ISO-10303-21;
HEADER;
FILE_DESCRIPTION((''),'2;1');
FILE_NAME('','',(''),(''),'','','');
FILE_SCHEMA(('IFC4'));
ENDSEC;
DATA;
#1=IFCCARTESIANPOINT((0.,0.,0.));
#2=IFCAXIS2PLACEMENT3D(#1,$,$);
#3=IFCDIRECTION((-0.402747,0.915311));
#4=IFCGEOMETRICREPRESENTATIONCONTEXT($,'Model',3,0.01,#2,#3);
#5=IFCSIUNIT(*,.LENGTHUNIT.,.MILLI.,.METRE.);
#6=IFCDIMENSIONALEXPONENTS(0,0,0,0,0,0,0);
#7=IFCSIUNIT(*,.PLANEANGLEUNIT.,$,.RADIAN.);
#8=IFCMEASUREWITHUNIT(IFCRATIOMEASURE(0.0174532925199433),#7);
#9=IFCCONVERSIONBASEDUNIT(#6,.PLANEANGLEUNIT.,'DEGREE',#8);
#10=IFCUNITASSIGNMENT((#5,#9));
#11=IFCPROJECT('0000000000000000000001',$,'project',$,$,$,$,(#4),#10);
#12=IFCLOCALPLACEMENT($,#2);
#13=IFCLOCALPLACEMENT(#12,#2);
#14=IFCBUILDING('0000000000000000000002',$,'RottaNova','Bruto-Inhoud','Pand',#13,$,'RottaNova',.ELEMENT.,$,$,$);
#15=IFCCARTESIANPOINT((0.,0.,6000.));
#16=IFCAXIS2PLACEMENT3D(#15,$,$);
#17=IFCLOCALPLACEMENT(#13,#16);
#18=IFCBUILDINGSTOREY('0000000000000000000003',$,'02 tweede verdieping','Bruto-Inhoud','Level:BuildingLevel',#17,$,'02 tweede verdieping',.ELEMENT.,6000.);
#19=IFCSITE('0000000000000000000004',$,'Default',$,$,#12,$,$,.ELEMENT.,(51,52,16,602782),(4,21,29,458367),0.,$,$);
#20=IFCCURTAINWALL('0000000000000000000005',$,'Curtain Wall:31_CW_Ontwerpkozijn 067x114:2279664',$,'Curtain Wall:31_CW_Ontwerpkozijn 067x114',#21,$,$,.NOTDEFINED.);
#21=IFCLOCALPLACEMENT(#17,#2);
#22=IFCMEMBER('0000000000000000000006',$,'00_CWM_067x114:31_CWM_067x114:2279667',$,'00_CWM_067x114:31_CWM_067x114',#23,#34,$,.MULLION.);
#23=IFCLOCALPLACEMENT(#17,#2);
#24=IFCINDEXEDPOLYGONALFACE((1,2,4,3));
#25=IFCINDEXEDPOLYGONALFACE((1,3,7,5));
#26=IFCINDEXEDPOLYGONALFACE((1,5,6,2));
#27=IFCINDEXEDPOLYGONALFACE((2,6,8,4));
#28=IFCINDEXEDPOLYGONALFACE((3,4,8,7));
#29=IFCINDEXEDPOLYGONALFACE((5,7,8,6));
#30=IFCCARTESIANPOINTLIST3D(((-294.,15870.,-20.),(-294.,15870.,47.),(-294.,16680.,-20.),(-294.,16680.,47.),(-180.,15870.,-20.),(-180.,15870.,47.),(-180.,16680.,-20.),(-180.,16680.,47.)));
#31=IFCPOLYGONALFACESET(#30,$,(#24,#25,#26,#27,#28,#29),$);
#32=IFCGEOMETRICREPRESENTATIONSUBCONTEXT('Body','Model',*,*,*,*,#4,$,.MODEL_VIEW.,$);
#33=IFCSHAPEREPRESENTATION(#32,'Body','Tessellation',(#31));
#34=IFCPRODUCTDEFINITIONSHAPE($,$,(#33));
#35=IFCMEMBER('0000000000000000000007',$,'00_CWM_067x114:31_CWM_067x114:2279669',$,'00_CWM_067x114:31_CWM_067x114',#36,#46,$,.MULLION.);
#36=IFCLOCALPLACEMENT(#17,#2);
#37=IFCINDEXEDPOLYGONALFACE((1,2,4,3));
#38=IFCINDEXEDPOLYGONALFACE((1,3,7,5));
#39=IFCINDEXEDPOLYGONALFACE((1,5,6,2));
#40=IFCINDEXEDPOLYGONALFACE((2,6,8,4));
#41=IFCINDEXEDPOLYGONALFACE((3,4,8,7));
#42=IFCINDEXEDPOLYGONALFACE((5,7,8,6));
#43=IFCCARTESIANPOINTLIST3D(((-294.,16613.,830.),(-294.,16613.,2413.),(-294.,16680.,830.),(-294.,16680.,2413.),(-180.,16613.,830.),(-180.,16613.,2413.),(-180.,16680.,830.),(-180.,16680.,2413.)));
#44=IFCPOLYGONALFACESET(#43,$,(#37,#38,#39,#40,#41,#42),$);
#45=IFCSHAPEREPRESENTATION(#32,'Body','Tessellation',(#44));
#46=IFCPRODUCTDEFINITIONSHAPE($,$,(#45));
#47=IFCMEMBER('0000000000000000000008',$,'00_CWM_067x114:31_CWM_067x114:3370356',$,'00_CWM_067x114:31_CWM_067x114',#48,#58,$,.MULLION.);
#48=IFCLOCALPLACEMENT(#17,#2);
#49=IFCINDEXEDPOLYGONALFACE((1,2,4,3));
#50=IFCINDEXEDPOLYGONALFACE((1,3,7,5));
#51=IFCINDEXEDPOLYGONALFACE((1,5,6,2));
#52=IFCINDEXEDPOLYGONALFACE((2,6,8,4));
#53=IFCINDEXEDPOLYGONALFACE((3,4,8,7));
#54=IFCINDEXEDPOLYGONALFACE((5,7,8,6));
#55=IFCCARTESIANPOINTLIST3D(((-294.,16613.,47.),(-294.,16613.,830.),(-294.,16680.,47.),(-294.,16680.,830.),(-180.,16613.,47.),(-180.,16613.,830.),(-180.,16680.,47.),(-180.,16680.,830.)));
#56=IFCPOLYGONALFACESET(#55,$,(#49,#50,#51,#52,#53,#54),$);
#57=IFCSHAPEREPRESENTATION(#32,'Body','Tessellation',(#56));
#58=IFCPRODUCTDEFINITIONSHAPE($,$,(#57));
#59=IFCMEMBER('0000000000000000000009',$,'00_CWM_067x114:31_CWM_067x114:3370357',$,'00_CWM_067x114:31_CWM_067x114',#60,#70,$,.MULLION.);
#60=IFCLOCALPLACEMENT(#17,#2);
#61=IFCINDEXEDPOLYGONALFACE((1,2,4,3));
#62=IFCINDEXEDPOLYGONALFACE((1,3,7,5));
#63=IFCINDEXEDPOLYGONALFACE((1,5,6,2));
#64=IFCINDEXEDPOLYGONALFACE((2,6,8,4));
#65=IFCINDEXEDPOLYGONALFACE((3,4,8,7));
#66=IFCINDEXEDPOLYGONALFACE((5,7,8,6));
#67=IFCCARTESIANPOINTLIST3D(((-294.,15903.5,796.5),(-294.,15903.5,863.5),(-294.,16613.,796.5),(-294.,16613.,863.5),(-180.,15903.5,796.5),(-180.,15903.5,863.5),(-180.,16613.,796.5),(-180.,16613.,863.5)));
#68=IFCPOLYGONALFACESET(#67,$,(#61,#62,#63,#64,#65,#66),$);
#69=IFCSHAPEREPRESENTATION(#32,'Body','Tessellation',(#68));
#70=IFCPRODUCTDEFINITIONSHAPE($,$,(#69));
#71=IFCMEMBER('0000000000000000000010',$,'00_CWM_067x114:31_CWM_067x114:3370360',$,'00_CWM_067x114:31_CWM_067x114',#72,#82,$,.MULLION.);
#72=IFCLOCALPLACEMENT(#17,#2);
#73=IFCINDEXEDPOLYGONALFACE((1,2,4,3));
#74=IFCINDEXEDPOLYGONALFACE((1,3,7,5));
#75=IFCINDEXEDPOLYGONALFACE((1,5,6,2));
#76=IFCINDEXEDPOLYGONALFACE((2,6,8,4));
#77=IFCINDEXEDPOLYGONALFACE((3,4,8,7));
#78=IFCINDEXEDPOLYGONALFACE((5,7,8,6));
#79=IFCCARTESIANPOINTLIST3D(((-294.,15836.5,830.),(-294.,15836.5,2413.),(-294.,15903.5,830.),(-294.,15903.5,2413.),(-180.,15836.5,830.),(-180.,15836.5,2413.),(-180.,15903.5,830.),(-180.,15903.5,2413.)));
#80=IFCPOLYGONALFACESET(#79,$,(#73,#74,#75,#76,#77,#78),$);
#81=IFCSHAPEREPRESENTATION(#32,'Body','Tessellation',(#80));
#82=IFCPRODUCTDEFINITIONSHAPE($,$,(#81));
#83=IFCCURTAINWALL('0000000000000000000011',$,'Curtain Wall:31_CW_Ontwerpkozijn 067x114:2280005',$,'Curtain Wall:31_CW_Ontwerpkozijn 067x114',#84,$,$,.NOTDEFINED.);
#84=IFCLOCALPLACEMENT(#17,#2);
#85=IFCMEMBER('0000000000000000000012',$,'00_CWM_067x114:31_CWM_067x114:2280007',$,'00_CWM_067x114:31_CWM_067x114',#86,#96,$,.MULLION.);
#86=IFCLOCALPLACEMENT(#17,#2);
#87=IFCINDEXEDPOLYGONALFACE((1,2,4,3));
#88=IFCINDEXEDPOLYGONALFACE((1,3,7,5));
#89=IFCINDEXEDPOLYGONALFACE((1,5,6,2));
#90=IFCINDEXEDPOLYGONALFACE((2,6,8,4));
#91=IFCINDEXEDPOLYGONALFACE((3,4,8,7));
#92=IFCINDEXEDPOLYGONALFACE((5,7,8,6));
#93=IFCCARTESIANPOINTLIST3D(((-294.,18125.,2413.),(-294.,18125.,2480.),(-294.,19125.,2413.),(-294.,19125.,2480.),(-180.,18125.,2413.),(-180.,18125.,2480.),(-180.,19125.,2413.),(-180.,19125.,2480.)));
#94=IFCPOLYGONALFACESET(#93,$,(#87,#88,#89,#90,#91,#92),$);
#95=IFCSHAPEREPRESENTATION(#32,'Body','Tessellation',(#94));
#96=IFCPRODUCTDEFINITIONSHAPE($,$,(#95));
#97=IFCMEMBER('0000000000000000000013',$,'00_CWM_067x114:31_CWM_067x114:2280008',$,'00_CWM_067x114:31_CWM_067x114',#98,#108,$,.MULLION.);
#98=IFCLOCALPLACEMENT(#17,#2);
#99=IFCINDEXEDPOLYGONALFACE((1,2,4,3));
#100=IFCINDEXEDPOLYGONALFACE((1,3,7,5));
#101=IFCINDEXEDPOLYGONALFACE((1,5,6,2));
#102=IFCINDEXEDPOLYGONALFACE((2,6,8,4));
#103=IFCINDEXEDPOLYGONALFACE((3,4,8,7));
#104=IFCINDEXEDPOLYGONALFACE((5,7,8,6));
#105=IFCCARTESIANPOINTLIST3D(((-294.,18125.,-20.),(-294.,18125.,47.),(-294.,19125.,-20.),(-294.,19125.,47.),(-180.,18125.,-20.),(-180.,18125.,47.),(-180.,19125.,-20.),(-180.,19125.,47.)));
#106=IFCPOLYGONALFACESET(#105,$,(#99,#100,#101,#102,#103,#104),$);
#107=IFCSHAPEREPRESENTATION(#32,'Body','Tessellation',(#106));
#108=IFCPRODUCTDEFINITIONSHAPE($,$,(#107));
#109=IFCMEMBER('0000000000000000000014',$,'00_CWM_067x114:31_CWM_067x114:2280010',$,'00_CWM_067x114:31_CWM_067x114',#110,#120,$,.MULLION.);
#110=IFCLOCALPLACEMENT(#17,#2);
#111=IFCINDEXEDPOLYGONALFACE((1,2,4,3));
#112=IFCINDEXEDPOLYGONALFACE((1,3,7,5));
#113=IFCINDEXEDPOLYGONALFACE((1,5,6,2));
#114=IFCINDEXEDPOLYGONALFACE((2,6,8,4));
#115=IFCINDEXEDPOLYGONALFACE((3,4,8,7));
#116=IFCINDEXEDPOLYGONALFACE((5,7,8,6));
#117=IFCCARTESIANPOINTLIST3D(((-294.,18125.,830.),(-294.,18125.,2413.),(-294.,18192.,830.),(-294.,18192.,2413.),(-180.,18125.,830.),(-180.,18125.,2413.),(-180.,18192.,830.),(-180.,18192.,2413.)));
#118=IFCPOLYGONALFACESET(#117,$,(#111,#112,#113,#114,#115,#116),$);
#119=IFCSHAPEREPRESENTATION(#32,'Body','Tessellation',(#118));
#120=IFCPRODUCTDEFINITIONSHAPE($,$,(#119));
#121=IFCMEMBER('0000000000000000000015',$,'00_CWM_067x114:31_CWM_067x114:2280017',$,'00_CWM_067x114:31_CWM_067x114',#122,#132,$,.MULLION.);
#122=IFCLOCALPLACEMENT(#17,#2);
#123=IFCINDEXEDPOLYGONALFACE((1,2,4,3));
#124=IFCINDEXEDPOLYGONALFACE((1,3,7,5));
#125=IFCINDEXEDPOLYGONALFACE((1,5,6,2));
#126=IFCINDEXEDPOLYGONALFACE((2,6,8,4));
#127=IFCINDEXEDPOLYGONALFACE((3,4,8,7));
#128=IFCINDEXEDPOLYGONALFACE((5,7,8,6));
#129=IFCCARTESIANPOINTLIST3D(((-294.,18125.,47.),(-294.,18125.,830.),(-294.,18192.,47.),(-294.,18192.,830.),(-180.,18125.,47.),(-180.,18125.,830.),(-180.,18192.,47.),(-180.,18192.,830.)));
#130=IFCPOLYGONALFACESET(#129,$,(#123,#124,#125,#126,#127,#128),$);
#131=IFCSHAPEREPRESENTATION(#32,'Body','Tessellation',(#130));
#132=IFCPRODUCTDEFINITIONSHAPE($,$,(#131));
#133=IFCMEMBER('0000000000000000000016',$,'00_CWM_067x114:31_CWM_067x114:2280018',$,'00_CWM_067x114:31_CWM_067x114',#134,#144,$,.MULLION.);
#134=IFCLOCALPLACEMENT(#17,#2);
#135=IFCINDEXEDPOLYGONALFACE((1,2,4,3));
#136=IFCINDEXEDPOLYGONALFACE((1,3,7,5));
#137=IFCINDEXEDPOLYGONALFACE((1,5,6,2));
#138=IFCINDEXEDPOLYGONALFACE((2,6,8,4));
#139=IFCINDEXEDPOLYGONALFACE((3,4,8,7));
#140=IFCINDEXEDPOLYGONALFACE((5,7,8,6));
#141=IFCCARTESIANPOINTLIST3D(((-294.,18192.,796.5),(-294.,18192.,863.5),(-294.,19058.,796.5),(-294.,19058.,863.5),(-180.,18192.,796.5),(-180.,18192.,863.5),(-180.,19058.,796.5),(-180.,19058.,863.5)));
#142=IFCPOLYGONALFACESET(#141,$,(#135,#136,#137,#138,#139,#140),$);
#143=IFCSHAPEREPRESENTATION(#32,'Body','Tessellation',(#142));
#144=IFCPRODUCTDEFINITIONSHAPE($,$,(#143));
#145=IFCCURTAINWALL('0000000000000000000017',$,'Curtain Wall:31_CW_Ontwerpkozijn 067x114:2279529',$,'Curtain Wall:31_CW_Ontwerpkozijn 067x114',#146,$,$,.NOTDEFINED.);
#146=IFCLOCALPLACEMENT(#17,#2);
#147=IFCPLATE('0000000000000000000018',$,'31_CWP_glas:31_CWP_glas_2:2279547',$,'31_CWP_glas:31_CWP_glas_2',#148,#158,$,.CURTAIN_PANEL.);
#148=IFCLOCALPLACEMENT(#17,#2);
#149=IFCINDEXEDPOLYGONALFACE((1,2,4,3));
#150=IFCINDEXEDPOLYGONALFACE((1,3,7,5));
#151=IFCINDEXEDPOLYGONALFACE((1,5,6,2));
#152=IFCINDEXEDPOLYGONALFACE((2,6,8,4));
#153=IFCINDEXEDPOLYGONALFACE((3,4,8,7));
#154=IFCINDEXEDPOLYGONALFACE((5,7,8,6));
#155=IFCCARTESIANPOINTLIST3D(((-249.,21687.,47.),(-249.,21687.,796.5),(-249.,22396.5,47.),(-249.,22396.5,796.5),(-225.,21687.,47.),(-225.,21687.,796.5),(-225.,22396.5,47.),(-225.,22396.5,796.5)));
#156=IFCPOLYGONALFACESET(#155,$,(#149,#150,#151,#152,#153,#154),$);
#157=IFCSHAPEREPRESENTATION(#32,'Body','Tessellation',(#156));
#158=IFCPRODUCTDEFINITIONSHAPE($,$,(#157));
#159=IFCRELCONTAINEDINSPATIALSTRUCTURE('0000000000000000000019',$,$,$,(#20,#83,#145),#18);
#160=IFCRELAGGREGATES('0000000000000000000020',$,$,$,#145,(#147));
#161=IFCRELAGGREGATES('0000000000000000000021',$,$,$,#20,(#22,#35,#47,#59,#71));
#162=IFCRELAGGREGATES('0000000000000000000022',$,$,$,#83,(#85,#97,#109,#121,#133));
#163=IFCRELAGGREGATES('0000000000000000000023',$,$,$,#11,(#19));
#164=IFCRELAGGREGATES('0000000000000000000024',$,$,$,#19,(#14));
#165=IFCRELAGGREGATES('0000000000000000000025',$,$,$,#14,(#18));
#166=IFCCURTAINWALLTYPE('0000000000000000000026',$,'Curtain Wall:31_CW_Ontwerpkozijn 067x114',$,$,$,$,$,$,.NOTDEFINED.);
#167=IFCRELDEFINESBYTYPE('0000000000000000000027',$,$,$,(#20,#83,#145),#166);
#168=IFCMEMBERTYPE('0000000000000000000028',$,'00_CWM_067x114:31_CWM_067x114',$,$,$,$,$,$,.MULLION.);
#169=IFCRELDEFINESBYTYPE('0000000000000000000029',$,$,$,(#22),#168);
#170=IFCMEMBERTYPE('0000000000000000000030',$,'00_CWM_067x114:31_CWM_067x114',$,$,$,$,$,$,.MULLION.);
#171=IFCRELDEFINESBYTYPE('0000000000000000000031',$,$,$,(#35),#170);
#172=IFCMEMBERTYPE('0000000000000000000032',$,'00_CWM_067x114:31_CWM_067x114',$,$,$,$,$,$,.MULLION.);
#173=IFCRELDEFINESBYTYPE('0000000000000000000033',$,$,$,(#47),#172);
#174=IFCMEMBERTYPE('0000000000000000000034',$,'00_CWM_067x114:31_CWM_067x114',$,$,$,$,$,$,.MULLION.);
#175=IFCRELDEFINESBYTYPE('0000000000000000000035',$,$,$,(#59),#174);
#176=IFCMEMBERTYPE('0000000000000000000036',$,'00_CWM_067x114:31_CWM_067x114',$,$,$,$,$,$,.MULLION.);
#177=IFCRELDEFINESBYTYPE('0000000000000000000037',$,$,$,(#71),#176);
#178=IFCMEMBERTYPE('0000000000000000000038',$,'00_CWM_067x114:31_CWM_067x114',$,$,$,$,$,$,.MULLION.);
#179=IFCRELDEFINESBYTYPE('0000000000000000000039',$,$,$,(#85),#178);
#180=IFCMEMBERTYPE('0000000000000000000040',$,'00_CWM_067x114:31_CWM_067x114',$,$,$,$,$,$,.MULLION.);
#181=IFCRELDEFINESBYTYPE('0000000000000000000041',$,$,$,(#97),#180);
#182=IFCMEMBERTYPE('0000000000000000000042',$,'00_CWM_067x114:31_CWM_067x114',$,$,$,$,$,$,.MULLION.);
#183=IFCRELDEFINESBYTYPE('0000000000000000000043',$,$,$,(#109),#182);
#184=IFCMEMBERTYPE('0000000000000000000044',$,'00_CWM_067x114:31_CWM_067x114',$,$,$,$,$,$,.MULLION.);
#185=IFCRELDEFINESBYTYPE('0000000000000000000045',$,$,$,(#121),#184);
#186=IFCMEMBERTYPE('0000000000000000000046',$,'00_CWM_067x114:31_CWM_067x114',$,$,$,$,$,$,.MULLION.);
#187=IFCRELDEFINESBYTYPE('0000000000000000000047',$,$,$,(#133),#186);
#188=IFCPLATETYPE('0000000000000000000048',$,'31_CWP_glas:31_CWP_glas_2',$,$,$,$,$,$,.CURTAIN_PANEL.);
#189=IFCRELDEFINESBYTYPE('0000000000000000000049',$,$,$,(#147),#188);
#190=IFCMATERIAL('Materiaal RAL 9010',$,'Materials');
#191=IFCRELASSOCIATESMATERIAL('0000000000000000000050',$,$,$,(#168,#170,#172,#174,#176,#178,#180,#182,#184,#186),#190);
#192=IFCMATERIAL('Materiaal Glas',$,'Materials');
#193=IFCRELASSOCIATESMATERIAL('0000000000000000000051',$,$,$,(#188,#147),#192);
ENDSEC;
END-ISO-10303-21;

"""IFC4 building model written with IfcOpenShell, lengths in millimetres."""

from ifc_helpers import new_model, entity, si_unit, converted_unit, direction, frame, frame_2d, origin, origin_2d_with_axis, place, context, subcontext, project, spatial, rectangle, extrude, source, transform, mapped, material, material_profile, profile_set, type_object, type_shapes, element, aggregate, save


model = new_model("IFC4")

# Units and contexts
model_context = context("Model", 3, precision=0.01, world=origin(), true_north=direction((-0.402747, 0.915311)))
body_context = subcontext(model_context, "Body", "Model", "MODEL_VIEW")
ifc_project = project(units=[si_unit("LENGTHUNIT", "METRE", prefix="MILLI"), converted_unit("PLANEANGLEUNIT", "DEGREE", entity("IfcRatioMeasure", 0.0174532925199433), si_unit("PLANEANGLEUNIT", "RADIAN"), dimensions=[0, 0, 0, 0, 0, 0, 0])], contexts=[model_context])

# Site, building, storey
site_placement = place(None, origin())
site = spatial("IfcSite", under=ifc_project, at=site_placement, Name="Default", CompositionType="ELEMENT", RefLatitude=(51, 52, 16, 602782), RefLongitude=(4, 21, 29, 458367), RefElevation=0.0)
building_placement = place(site_placement, origin())
building = spatial("IfcBuilding", under=site, at=building_placement, Name="RottaNova", Description="Bruto-Inhoud", ObjectType="Pand", LongName="RottaNova", CompositionType="ELEMENT")
storey_placement = place(building_placement, frame((0.0, 0.0, 6000.0)))
storey = spatial("IfcBuildingStorey", under=building, at=storey_placement, Name="02 tweede verdieping", Description="Bruto-Inhoud", ObjectType="Level:BuildingLevel", LongName="02 tweede verdieping", CompositionType="ELEMENT", Elevation=6000.0)

# Curtain walls, members
curtain_wall_type = type_object("IfcCurtainWallType", Name="Curtain Wall:31_CW_Ontwerpkozijn 067x114", PredefinedType="NOTDEFINED")
curtain_wall_1_placement = place(storey_placement, frame((0.0, 0.0, -6000.0)))
curtain_wall_1 = element("IfcCurtainWall", 1, at=curtain_wall_1_placement, inside=storey, type_object=curtain_wall_type, Name="Curtain Wall:31_CW_Ontwerpkozijn 067x114:2279664", ObjectType="Curtain Wall:31_CW_Ontwerpkozijn 067x114", PredefinedType="NOTDEFINED")
ifc_material_1 = material(Name="Materiaal RAL 9010", Category="Materials")
ifc_material_profile = material_profile(ifc_material_1, rectangle(XDim=114.0, YDim=67.0, at=origin_2d_with_axis()), Name="31_CWM_067x114")
ifc_profile_set = profile_set([ifc_material_profile], Name="31_CWM_067x114")
member_type_1 = type_object("IfcMemberType", Name="00_CWM_067x114:31_CWM_067x114", PredefinedType="MULLION", material=ifc_profile_set)
shared_shape_1 = source(origin(), body_context, "Body", "SweptSolid", [
    extrude(rectangle(XDim=114.0, YDim=67.0, at=origin_2d_with_axis()), frame((-33.5, 57.0, -810.0), z_axis=(0.0, 0.0, 1.0), x_axis=(0.0, -1.0, 0.0)), (0.0, 0.0, 1.0), 810.0),
])
type_shapes(member_type_1, [shared_shape_1])
member_1_placement = place(curtain_wall_1_placement, frame((-180.0, 16680.0, 5980.0), z_axis=(0.0, 1.0, 0.0), x_axis=(0.0, 0.0, -1.0)))
member_1 = element("IfcMember", 2, at=member_1_placement, type_object=member_type_1, Name="00_CWM_067x114:31_CWM_067x114:2279667", ObjectType="00_CWM_067x114:31_CWM_067x114", PredefinedType="MULLION", context=body_context, shape_type="MappedRepresentation", body=[
    mapped(shared_shape_1, transform((0.0, 0.0, 0.0), scale=1.0)),
])
member_type_2 = type_object("IfcMemberType", Name="00_CWM_067x114:31_CWM_067x114", PredefinedType="MULLION", material=ifc_profile_set)
shared_shape_2 = source(origin(), body_context, "Body", "SweptSolid", [
    extrude(rectangle(XDim=114.0, YDim=67.0, at=origin_2d_with_axis()), frame((-33.5, 57.0, -1583.0), z_axis=(0.0, 0.0, 1.0), x_axis=(0.0, -1.0, 0.0)), (0.0, 0.0, 1.0), 1583.0),
])
type_shapes(member_type_2, [shared_shape_2])
member_2_placement = place(curtain_wall_1_placement, frame((-180.0, 16680.0, 8413.0), z_axis=(0.0, 0.0, 1.0), x_axis=(0.0, 1.0, 0.0)))
member_2 = element("IfcMember", 3, at=member_2_placement, type_object=member_type_2, Name="00_CWM_067x114:31_CWM_067x114:2279669", ObjectType="00_CWM_067x114:31_CWM_067x114", PredefinedType="MULLION", context=body_context, shape_type="MappedRepresentation", body=[
    mapped(shared_shape_2, transform((0.0, 0.0, 0.0), scale=1.0)),
])
member_type_3 = type_object("IfcMemberType", Name="00_CWM_067x114:31_CWM_067x114", PredefinedType="MULLION", material=ifc_profile_set)
shared_shape_3 = source(origin(), body_context, "Body", "SweptSolid", [
    extrude(rectangle(XDim=114.0, YDim=67.0, at=origin_2d_with_axis()), frame((-33.5, 57.0, -783.0), z_axis=(0.0, 0.0, 1.0), x_axis=(0.0, -1.0, 0.0)), (0.0, 0.0, 1.0), 783.0),
])
type_shapes(member_type_3, [shared_shape_3])
member_3_placement = place(curtain_wall_1_placement, frame((-180.0, 16680.0, 6830.0), z_axis=(0.0, 0.0, 1.0), x_axis=(0.0, 1.0, 0.0)))
member_3 = element("IfcMember", 4, at=member_3_placement, type_object=member_type_3, Name="00_CWM_067x114:31_CWM_067x114:3370356", ObjectType="00_CWM_067x114:31_CWM_067x114", PredefinedType="MULLION", context=body_context, shape_type="MappedRepresentation", body=[
    mapped(shared_shape_3, transform((0.0, 0.0, 0.0), scale=1.0)),
])
member_type_4 = type_object("IfcMemberType", Name="00_CWM_067x114:31_CWM_067x114", PredefinedType="MULLION", material=ifc_profile_set)
shared_shape_4 = source(origin(), body_context, "Body", "SweptSolid", [
    extrude(rectangle(XDim=114.0, YDim=67.0, at=origin_2d_with_axis()), frame((0.0, 57.0, -709.5), z_axis=(0.0, 0.0, 1.0), x_axis=(0.0, -1.0, 0.0)), (0.0, 0.0, 1.0), 709.5),
])
type_shapes(member_type_4, [shared_shape_4])
member_4_placement = place(curtain_wall_1_placement, frame((-180.0, 15903.5, 6830.0), z_axis=(0.0, -1.0, 0.0), x_axis=(0.0, 0.0, 1.0)))
member_4 = element("IfcMember", 5, at=member_4_placement, type_object=member_type_4, Name="00_CWM_067x114:31_CWM_067x114:3370357", ObjectType="00_CWM_067x114:31_CWM_067x114", PredefinedType="MULLION", context=body_context, shape_type="MappedRepresentation", body=[
    mapped(shared_shape_4, transform((0.0, 0.0, 0.0), scale=1.0)),
])
member_type_5 = type_object("IfcMemberType", Name="00_CWM_067x114:31_CWM_067x114", PredefinedType="MULLION", material=ifc_profile_set)
shared_shape_5 = source(origin(), body_context, "Body", "SweptSolid", [
    extrude(rectangle(XDim=114.0, YDim=67.0, at=origin_2d_with_axis()), frame((0.0, 57.0, -1583.0), z_axis=(0.0, 0.0, 1.0), x_axis=(0.0, -1.0, 0.0)), (0.0, 0.0, 1.0), 1583.0),
])
type_shapes(member_type_5, [shared_shape_5])
member_5_placement = place(curtain_wall_1_placement, frame((-180.0, 15870.0, 6830.0), z_axis=(0.0, 0.0, -1.0), x_axis=(0.0, -1.0, 0.0)))
member_5 = element("IfcMember", 6, at=member_5_placement, type_object=member_type_5, Name="00_CWM_067x114:31_CWM_067x114:3370360", ObjectType="00_CWM_067x114:31_CWM_067x114", PredefinedType="MULLION", context=body_context, shape_type="MappedRepresentation", body=[
    mapped(shared_shape_5, transform((0.0, 0.0, 0.0), scale=1.0)),
])
curtain_wall_2_placement = place(storey_placement, frame((0.0, 0.0, -6000.0)))
curtain_wall_2 = element("IfcCurtainWall", 7, at=curtain_wall_2_placement, inside=storey, type_object=curtain_wall_type, Name="Curtain Wall:31_CW_Ontwerpkozijn 067x114:2280005", ObjectType="Curtain Wall:31_CW_Ontwerpkozijn 067x114", PredefinedType="NOTDEFINED")
member_type_6 = type_object("IfcMemberType", Name="00_CWM_067x114:31_CWM_067x114", PredefinedType="MULLION", material=ifc_profile_set)
shared_shape_6 = source(origin(), body_context, "Body", "SweptSolid", [
    extrude(rectangle(XDim=114.0, YDim=67.0, at=frame_2d((0.0, 0.0), x_axis=(1.0, 0.0))), frame((-33.5, -57.0, -1000.0), z_axis=(0.0, 0.0, 1.0), x_axis=(0.0, -1.0, 0.0)), (0.0, 0.0, 1.0), 1000.0),
])
type_shapes(member_type_6, [shared_shape_6])
member_6_placement = place(curtain_wall_2_placement, frame((-180.0, 19125.0, 8480.0), z_axis=(0.0, 1.0, 0.0), x_axis=(0.0, 0.0, 1.0)))
member_6 = element("IfcMember", 8, at=member_6_placement, type_object=member_type_6, Name="00_CWM_067x114:31_CWM_067x114:2280007", ObjectType="00_CWM_067x114:31_CWM_067x114", PredefinedType="MULLION", context=body_context, shape_type="MappedRepresentation", body=[
    mapped(shared_shape_6, transform((0.0, 0.0, 0.0), scale=1.0)),
])
member_type_7 = type_object("IfcMemberType", Name="00_CWM_067x114:31_CWM_067x114", PredefinedType="MULLION", material=ifc_profile_set)
shared_shape_7 = source(origin(), body_context, "Body", "SweptSolid", [
    extrude(rectangle(XDim=114.0, YDim=67.0, at=frame_2d((0.0, 0.0), x_axis=(1.0, 0.0))), frame((-33.5, -57.0, -1000.0), z_axis=(0.0, 0.0, 1.0), x_axis=(0.0, -1.0, 0.0)), (0.0, 0.0, 1.0), 1000.0),
])
type_shapes(member_type_7, [shared_shape_7])
member_7_placement = place(curtain_wall_2_placement, frame((-180.0, 18125.0, 5980.0), z_axis=(0.0, -1.0, 0.0), x_axis=(0.0, 0.0, -1.0)))
member_7 = element("IfcMember", 9, at=member_7_placement, type_object=member_type_7, Name="00_CWM_067x114:31_CWM_067x114:2280008", ObjectType="00_CWM_067x114:31_CWM_067x114", PredefinedType="MULLION", context=body_context, shape_type="MappedRepresentation", body=[
    mapped(shared_shape_7, transform((0.0, 0.0, 0.0), scale=1.0)),
])
member_type_8 = type_object("IfcMemberType", Name="00_CWM_067x114:31_CWM_067x114", PredefinedType="MULLION", material=ifc_profile_set)
shared_shape_8 = source(origin(), body_context, "Body", "SweptSolid", [
    extrude(rectangle(XDim=114.0, YDim=67.0, at=frame_2d((0.0, 0.0), x_axis=(1.0, 0.0))), frame((-33.5, -57.0, -1583.0), z_axis=(0.0, 0.0, 1.0), x_axis=(0.0, -1.0, 0.0)), (0.0, 0.0, 1.0), 1583.0),
])
type_shapes(member_type_8, [shared_shape_8])
member_8_placement = place(curtain_wall_2_placement, frame((-180.0, 18125.0, 8413.0), z_axis=(0.0, 0.0, 1.0), x_axis=(0.0, -1.0, 0.0)))
member_8 = element("IfcMember", 10, at=member_8_placement, type_object=member_type_8, Name="00_CWM_067x114:31_CWM_067x114:2280010", ObjectType="00_CWM_067x114:31_CWM_067x114", PredefinedType="MULLION", context=body_context, shape_type="MappedRepresentation", body=[
    mapped(shared_shape_8, transform((0.0, 0.0, 0.0), scale=1.0)),
])
member_type_9 = type_object("IfcMemberType", Name="00_CWM_067x114:31_CWM_067x114", PredefinedType="MULLION", material=ifc_profile_set)
shared_shape_9 = source(origin(), body_context, "Body", "SweptSolid", [
    extrude(rectangle(XDim=114.0, YDim=67.0, at=frame_2d((0.0, 0.0), x_axis=(1.0, 0.0))), frame((-33.5, -57.0, -783.0), z_axis=(0.0, 0.0, 1.0), x_axis=(0.0, -1.0, 0.0)), (0.0, 0.0, 1.0), 783.0),
])
type_shapes(member_type_9, [shared_shape_9])
member_9_placement = place(curtain_wall_2_placement, frame((-180.0, 18125.0, 6830.0), z_axis=(0.0, 0.0, 1.0), x_axis=(0.0, -1.0, 0.0)))
member_9 = element("IfcMember", 11, at=member_9_placement, type_object=member_type_9, Name="00_CWM_067x114:31_CWM_067x114:2280017", ObjectType="00_CWM_067x114:31_CWM_067x114", PredefinedType="MULLION", context=body_context, shape_type="MappedRepresentation", body=[
    mapped(shared_shape_9, transform((0.0, 0.0, 0.0), scale=1.0)),
])
member_type_10 = type_object("IfcMemberType", Name="00_CWM_067x114:31_CWM_067x114", PredefinedType="MULLION", material=ifc_profile_set)
shared_shape_10 = source(origin(), body_context, "Body", "SweptSolid", [
    extrude(rectangle(XDim=114.0, YDim=67.0, at=origin_2d_with_axis()), frame((0.0, -57.0, -866.0), z_axis=(0.0, 0.0, 1.0), x_axis=(0.0, -1.0, 0.0)), (0.0, 0.0, 1.0), 866.0),
])
type_shapes(member_type_10, [shared_shape_10])
member_10_placement = place(curtain_wall_2_placement, frame((-180.0, 19058.0, 6830.0), z_axis=(0.0, 1.0, 0.0), x_axis=(0.0, 0.0, 1.0)))
member_10 = element("IfcMember", 12, at=member_10_placement, type_object=member_type_10, Name="00_CWM_067x114:31_CWM_067x114:2280018", ObjectType="00_CWM_067x114:31_CWM_067x114", PredefinedType="MULLION", context=body_context, shape_type="MappedRepresentation", body=[
    mapped(shared_shape_10, transform((0.0, 0.0, 0.0), scale=1.0)),
])

# Curtain wall, plate
curtain_wall_3_placement = place(storey_placement, frame((0.0, 0.0, -6000.0)))
curtain_wall_3 = element("IfcCurtainWall", 13, at=curtain_wall_3_placement, inside=storey, type_object=curtain_wall_type, Name="Curtain Wall:31_CW_Ontwerpkozijn 067x114:2279529", ObjectType="Curtain Wall:31_CW_Ontwerpkozijn 067x114", PredefinedType="NOTDEFINED")
ifc_material_2 = material(Name="Materiaal Glas", Category="Materials")
plate_type_1 = type_object("IfcPlateType", Name="31_CWP_glas:31_CWP_glas_2", PredefinedType="CURTAIN_PANEL", material=ifc_material_2)
shared_shape_11 = source(origin(), body_context, "Body", "SweptSolid", [
    extrude(rectangle(XDim=24.0, YDim=709.5, at=frame_2d((0.0, 0.0), x_axis=(1.0, 0.0))), frame((354.8, 12.0, 0.0), z_axis=(0.0, 0.0, 1.0), x_axis=(0.0, 1.0, 0.0)), (0.0, 0.0, 1.0), 749.5),
])
type_shapes(plate_type_1, [shared_shape_11])
plate_1_placement = place(curtain_wall_3_placement, frame((-249.0, 22396.5, 6047.0), z_axis=(0.0, 0.0, 1.0), x_axis=(0.0, -1.0, 0.0)))
plate_1 = element("IfcPlate", 14, at=plate_1_placement, type_object=plate_type_1, material=ifc_material_2, Name="31_CWP_glas:31_CWP_glas_2:2279547", ObjectType="31_CWP_glas:31_CWP_glas_2", PredefinedType="CURTAIN_PANEL", context=body_context, shape_type="MappedRepresentation", body=[
    mapped(shared_shape_11, transform((0.0, 0.0, 0.0), scale=1.0)),
])

aggregate(curtain_wall_3, [plate_1])

aggregate(curtain_wall_1, [member_1, member_2, member_3, member_4, member_5])
aggregate(curtain_wall_2, [member_6, member_7, member_8, member_9, member_10])

save(model, "model.ifc")
